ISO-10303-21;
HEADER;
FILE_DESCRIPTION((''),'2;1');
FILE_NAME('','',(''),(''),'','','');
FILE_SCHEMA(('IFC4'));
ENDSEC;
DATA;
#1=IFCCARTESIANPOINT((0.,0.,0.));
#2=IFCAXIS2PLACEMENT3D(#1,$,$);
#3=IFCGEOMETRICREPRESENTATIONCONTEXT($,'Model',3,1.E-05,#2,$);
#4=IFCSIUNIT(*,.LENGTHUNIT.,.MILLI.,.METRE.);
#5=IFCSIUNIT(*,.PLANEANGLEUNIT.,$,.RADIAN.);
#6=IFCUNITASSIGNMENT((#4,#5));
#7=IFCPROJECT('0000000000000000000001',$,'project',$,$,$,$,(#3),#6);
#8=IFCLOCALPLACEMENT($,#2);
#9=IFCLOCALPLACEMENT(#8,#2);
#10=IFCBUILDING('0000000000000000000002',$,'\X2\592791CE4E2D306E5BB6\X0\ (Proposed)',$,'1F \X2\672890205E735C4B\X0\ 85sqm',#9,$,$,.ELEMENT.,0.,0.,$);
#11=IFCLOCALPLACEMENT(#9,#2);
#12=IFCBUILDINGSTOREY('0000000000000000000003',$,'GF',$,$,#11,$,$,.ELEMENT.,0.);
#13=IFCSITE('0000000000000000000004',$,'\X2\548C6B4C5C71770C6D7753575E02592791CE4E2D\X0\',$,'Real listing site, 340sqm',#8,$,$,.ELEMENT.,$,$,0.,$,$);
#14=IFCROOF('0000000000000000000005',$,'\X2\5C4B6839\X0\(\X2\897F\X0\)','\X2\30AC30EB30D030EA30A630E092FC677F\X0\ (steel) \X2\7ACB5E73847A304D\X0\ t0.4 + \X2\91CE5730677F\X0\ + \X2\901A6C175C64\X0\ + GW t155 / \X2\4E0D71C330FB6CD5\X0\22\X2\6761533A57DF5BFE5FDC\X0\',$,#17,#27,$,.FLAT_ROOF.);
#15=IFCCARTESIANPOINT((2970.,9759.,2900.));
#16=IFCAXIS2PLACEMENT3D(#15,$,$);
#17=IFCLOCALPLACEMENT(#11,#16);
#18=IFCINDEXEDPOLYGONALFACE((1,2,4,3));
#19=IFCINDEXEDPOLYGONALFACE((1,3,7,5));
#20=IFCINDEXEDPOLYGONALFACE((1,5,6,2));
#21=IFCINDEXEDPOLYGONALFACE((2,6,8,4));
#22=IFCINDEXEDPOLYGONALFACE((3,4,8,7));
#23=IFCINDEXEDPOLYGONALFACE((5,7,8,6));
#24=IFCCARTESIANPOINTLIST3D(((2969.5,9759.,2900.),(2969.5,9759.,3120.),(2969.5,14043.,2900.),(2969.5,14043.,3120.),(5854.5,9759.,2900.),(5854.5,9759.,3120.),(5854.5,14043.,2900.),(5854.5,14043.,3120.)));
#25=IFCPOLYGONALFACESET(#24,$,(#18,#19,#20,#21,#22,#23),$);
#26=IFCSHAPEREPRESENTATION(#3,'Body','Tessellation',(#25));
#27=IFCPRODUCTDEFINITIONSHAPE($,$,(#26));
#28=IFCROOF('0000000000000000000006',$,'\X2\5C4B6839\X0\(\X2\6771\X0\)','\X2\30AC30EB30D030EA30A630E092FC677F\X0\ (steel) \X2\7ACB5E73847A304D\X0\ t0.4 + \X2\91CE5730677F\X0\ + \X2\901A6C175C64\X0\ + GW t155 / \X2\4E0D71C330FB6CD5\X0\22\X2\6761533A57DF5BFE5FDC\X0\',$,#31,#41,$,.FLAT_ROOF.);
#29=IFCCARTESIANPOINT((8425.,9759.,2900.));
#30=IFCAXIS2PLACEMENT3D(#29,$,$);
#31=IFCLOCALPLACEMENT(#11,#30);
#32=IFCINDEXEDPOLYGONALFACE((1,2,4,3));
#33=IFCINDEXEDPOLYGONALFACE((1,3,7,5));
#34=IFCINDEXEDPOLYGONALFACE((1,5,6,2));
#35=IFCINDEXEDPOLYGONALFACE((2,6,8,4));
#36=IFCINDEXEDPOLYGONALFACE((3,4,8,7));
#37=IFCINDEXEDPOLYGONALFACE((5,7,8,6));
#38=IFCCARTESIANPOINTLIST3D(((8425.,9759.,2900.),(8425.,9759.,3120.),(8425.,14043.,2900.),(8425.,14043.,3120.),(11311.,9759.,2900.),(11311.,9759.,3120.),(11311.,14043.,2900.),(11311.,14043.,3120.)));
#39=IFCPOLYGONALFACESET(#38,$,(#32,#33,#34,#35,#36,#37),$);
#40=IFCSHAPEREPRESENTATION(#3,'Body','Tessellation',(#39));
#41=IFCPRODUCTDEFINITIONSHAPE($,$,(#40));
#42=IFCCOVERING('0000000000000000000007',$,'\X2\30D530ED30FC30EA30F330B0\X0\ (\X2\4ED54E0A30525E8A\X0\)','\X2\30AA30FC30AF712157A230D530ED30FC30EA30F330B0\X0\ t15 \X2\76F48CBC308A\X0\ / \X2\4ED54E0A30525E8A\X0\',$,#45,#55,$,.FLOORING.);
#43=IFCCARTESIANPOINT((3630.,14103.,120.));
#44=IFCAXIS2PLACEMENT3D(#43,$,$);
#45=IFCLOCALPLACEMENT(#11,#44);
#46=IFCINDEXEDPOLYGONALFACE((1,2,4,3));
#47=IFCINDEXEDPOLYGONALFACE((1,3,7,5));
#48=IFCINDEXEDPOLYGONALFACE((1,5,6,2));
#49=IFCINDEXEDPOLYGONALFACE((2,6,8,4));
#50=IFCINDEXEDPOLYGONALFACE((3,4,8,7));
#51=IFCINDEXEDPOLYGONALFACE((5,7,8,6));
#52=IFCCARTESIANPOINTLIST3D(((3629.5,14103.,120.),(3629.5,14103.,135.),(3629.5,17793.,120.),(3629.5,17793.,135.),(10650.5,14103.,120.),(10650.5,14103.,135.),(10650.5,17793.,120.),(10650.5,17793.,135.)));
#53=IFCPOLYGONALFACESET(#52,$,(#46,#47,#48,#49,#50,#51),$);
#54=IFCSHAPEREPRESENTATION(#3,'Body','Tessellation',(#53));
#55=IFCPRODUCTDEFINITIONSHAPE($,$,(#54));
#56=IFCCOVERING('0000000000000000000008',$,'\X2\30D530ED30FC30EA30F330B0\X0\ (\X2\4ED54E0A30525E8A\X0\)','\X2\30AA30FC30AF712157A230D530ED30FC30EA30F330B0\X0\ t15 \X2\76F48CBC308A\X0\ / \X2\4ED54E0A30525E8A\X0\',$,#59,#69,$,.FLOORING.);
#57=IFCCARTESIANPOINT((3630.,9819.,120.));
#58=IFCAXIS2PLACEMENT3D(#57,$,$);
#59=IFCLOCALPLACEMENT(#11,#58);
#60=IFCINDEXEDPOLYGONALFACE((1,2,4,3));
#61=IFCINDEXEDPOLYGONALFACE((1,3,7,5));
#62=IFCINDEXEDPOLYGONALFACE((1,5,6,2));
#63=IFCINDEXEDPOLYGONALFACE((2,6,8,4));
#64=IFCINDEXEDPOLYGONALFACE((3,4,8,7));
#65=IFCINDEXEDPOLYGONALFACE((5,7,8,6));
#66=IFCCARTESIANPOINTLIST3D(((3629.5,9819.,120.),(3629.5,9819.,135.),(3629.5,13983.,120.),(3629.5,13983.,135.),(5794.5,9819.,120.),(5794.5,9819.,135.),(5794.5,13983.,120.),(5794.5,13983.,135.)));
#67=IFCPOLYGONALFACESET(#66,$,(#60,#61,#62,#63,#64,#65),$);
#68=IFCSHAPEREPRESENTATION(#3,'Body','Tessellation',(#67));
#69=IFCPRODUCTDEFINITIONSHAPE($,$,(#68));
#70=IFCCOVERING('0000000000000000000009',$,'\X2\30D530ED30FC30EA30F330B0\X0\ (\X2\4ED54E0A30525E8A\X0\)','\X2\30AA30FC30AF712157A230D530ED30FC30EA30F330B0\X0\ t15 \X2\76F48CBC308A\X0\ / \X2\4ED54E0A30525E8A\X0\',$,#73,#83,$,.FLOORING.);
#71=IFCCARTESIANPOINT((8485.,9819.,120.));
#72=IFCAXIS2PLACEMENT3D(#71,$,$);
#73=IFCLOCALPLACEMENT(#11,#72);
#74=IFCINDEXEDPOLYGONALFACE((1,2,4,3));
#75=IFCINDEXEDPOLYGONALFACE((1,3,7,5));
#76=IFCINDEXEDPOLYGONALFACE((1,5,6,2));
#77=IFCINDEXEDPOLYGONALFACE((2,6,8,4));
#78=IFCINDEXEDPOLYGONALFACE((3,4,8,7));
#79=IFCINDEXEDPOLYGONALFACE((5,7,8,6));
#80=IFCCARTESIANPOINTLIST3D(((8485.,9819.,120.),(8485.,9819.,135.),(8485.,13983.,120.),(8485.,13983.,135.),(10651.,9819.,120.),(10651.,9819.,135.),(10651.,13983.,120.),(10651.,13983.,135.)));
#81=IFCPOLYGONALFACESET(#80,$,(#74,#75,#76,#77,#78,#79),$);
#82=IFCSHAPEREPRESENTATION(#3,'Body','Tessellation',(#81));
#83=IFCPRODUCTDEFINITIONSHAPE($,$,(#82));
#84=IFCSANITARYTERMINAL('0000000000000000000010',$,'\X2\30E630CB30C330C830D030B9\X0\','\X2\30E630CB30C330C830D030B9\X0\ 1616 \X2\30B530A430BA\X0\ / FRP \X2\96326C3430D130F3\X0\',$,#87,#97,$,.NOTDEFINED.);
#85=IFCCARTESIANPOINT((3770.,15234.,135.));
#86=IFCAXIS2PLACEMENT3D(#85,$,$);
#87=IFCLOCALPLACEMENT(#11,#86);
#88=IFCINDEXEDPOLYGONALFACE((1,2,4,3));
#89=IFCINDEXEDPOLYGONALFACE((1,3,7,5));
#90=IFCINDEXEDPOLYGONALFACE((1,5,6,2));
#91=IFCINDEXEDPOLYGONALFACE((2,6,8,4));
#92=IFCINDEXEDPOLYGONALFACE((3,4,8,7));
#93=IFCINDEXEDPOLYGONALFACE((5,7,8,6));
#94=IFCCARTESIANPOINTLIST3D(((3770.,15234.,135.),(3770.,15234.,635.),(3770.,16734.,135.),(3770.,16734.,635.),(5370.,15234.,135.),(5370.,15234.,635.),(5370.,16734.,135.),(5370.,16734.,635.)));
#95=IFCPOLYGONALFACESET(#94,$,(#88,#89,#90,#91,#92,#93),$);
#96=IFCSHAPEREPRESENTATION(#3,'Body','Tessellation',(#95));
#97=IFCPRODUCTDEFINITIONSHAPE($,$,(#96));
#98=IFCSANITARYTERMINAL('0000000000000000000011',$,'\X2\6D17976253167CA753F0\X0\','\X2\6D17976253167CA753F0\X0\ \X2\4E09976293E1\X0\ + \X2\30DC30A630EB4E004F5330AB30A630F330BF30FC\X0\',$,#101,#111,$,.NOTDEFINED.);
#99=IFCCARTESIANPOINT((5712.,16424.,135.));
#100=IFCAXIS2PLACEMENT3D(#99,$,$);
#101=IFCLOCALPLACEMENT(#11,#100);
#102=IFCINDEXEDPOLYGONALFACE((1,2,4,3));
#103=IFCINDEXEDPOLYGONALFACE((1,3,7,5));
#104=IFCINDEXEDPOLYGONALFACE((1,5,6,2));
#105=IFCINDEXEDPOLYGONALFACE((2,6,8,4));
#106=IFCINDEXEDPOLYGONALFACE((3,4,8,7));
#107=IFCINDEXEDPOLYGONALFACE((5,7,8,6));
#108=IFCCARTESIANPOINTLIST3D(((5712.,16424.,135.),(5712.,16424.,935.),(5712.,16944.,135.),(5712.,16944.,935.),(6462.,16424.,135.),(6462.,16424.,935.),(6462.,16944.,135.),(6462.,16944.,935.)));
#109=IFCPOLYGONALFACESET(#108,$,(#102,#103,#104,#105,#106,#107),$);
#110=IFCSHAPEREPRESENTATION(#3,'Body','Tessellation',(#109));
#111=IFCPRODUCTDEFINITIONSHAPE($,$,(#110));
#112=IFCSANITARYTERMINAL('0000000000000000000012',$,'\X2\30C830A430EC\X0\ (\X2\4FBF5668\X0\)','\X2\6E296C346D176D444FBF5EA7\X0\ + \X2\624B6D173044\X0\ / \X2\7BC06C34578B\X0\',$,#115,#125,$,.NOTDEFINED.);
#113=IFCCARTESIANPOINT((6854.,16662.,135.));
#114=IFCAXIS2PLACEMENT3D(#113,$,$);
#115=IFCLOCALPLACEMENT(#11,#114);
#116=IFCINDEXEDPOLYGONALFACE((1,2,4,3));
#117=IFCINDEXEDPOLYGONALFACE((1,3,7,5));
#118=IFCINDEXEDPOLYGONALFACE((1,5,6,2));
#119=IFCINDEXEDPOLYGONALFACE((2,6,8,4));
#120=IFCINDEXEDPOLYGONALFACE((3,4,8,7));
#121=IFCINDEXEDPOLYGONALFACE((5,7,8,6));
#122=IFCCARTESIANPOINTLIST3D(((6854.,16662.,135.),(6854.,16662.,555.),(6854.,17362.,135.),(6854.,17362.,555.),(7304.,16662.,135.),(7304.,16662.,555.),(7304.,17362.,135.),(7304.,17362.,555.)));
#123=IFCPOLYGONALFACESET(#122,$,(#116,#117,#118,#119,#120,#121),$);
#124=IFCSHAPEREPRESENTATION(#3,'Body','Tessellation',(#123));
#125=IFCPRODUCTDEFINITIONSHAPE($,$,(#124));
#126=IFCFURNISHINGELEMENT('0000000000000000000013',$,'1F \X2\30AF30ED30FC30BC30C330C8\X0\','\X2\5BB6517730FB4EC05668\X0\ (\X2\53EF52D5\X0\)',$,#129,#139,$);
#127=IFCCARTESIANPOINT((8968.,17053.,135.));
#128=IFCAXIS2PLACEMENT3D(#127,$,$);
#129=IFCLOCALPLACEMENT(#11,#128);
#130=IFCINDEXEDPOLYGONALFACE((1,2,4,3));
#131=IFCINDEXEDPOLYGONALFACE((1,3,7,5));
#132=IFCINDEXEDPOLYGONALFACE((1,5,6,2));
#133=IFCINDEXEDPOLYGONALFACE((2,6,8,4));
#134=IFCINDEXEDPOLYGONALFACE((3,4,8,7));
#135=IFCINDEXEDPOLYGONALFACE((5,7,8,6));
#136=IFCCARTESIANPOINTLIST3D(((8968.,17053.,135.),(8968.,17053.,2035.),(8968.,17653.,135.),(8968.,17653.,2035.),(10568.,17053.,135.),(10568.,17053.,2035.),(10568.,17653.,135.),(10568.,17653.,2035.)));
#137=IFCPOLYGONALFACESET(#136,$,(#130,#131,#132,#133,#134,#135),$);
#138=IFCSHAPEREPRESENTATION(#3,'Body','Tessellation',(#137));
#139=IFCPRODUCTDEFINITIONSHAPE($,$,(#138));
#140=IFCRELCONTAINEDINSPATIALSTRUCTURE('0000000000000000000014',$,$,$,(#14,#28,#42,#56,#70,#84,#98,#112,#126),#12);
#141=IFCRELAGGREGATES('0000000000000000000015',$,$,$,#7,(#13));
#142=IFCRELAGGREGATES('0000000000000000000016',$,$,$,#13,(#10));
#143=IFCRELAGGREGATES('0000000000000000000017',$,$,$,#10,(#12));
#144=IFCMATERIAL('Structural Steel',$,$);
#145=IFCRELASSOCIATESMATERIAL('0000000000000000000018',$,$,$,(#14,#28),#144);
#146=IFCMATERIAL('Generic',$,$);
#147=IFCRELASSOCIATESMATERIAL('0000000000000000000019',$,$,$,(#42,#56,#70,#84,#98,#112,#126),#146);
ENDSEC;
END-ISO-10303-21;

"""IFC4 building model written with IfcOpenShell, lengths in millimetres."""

from ifc_helpers import new_model, si_unit, frame, frame_2d, origin, place, context, project, spatial, rectangle, extrude, material, element, save


model = new_model("IFC4")

# Units and contexts
model_context = context("Model", 3, precision=1e-05, world=origin())
ifc_project = project(units=[si_unit("LENGTHUNIT", "METRE", prefix="MILLI"), si_unit("PLANEANGLEUNIT", "RADIAN")], contexts=[model_context])

# Site, building, storey
site_placement = place(None, origin())
site = spatial("IfcSite", under=ifc_project, at=site_placement, Name="和歌山県海南市大野中", ObjectType="Real listing site, 340sqm", CompositionType="ELEMENT", RefElevation=0.0)
building_placement = place(site_placement, origin())
building = spatial("IfcBuilding", under=site, at=building_placement, Name="大野中の家 (Proposed)", ObjectType="1F 木造平屋 85sqm", CompositionType="ELEMENT", ElevationOfRefHeight=0.0, ElevationOfTerrain=0.0)
storey_placement = place(building_placement, origin())
storey = spatial("IfcBuildingStorey", under=building, at=storey_placement, Name="GF", CompositionType="ELEMENT", Elevation=0.0)

# Roofs
ifc_material_1 = material(Name="Structural Steel")
roof_1_placement = place(storey_placement, frame((2970.0, 9759.0, 2900.0)))
element("IfcRoof", 1, at=roof_1_placement, inside=storey, material=ifc_material_1, Name="屋根(西)", Description="ガルバリウム鋼板 (steel) 立平葺き t0.4 + 野地板 + 通気層 + GW t155 / 不燃・法22条区域対応", PredefinedType="FLAT_ROOF", context=model_context, shape_type="SweptSolid", body=[
    extrude(rectangle(XDim=2885.0, YDim=4284.0, at=frame_2d((1442.0, 2142.0))), frame((2970.0, 9759.0, 2900.0)), (0.0, 0.0, 1.0), 220.0),
])
roof_2_placement = place(storey_placement, frame((8425.0, 9759.0, 2900.0)))
element("IfcRoof", 2, at=roof_2_placement, inside=storey, material=ifc_material_1, Name="屋根(東)", Description="ガルバリウム鋼板 (steel) 立平葺き t0.4 + 野地板 + 通気層 + GW t155 / 不燃・法22条区域対応", PredefinedType="FLAT_ROOF", context=model_context, shape_type="SweptSolid", body=[
    extrude(rectangle(XDim=2886.0, YDim=4284.0, at=frame_2d((1443.0, 2142.0))), frame((8425.0, 9759.0, 2900.0)), (0.0, 0.0, 1.0), 220.0),
])

# Coverings
ifc_material_2 = material(Name="Generic")
covering_1_placement = place(storey_placement, frame((3630.0, 14103.0, 120.0)))
element("IfcCovering", 3, at=covering_1_placement, inside=storey, material=ifc_material_2, Name="フローリング (仕上げ床)", Description="オーク無垢フローリング t15 直貼り / 仕上げ床", PredefinedType="FLOORING", context=model_context, shape_type="SweptSolid", body=[
    extrude(rectangle(XDim=7021.0, YDim=3690.0, at=frame_2d((3510.0, 1845.0))), frame((3630.0, 14103.0, 120.0)), (0.0, 0.0, 1.0), 15.0),
])
covering_2_placement = place(storey_placement, frame((3630.0, 9819.0, 120.0)))
element("IfcCovering", 4, at=covering_2_placement, inside=storey, material=ifc_material_2, Name="フローリング (仕上げ床)", Description="オーク無垢フローリング t15 直貼り / 仕上げ床", PredefinedType="FLOORING", context=model_context, shape_type="SweptSolid", body=[
    extrude(rectangle(XDim=2165.0, YDim=4164.0, at=frame_2d((1082.0, 2082.0))), frame((3630.0, 9819.0, 120.0)), (0.0, 0.0, 1.0), 15.0),
])
covering_3_placement = place(storey_placement, frame((8485.0, 9819.0, 120.0)))
element("IfcCovering", 5, at=covering_3_placement, inside=storey, material=ifc_material_2, Name="フローリング (仕上げ床)", Description="オーク無垢フローリング t15 直貼り / 仕上げ床", PredefinedType="FLOORING", context=model_context, shape_type="SweptSolid", body=[
    extrude(rectangle(XDim=2166.0, YDim=4164.0, at=frame_2d((1083.0, 2082.0))), frame((8485.0, 9819.0, 120.0)), (0.0, 0.0, 1.0), 15.0),
])

# Sanitary terminals
sanitary_terminal_1_placement = place(storey_placement, frame((3770.0, 15234.0, 135.0)))
element("IfcSanitaryTerminal", 6, at=sanitary_terminal_1_placement, inside=storey, material=ifc_material_2, Name="ユニットバス", Description="ユニットバス 1616 サイズ / FRP 防水パン", PredefinedType="NOTDEFINED", context=model_context, shape_type="SweptSolid", body=[
    extrude(rectangle(XDim=1600.0, YDim=1500.0, at=frame_2d((800.0, 750.0))), frame((3770.0, 15234.0, 135.0)), (0.0, 0.0, 1.0), 500.0),
])
sanitary_terminal_2_placement = place(storey_placement, frame((5712.0, 16424.0, 135.0)))
element("IfcSanitaryTerminal", 7, at=sanitary_terminal_2_placement, inside=storey, material=ifc_material_2, Name="洗面化粧台", Description="洗面化粧台 三面鏡 + ボウル一体カウンター", PredefinedType="NOTDEFINED", context=model_context, shape_type="SweptSolid", body=[
    extrude(rectangle(XDim=750.0, YDim=520.0, at=frame_2d((375.0, 260.0))), frame((5712.0, 16424.0, 135.0)), (0.0, 0.0, 1.0), 800.0),
])
sanitary_terminal_3_placement = place(storey_placement, frame((6854.0, 16662.0, 135.0)))
element("IfcSanitaryTerminal", 8, at=sanitary_terminal_3_placement, inside=storey, material=ifc_material_2, Name="トイレ (便器)", Description="温水洗浄便座 + 手洗い / 節水型", PredefinedType="NOTDEFINED", context=model_context, shape_type="SweptSolid", body=[
    extrude(rectangle(XDim=450.0, YDim=700.0, at=frame_2d((225.0, 350.0))), frame((6854.0, 16662.0, 135.0)), (0.0, 0.0, 1.0), 420.0),
])

# Furnishing element
furnishing_placement = place(storey_placement, frame((8968.0, 17053.0, 135.0)))
element("IfcFurnishingElement", 9, at=furnishing_placement, inside=storey, material=ifc_material_2, Name="1F クローゼット", Description="家具・什器 (可動)", context=model_context, shape_type="SweptSolid", body=[
    extrude(rectangle(XDim=1600.0, YDim=600.0, at=frame_2d((800.0, 300.0))), frame((8968.0, 17053.0, 135.0)), (0.0, 0.0, 1.0), 1900.0),
])

save(model, "model.ifc")
